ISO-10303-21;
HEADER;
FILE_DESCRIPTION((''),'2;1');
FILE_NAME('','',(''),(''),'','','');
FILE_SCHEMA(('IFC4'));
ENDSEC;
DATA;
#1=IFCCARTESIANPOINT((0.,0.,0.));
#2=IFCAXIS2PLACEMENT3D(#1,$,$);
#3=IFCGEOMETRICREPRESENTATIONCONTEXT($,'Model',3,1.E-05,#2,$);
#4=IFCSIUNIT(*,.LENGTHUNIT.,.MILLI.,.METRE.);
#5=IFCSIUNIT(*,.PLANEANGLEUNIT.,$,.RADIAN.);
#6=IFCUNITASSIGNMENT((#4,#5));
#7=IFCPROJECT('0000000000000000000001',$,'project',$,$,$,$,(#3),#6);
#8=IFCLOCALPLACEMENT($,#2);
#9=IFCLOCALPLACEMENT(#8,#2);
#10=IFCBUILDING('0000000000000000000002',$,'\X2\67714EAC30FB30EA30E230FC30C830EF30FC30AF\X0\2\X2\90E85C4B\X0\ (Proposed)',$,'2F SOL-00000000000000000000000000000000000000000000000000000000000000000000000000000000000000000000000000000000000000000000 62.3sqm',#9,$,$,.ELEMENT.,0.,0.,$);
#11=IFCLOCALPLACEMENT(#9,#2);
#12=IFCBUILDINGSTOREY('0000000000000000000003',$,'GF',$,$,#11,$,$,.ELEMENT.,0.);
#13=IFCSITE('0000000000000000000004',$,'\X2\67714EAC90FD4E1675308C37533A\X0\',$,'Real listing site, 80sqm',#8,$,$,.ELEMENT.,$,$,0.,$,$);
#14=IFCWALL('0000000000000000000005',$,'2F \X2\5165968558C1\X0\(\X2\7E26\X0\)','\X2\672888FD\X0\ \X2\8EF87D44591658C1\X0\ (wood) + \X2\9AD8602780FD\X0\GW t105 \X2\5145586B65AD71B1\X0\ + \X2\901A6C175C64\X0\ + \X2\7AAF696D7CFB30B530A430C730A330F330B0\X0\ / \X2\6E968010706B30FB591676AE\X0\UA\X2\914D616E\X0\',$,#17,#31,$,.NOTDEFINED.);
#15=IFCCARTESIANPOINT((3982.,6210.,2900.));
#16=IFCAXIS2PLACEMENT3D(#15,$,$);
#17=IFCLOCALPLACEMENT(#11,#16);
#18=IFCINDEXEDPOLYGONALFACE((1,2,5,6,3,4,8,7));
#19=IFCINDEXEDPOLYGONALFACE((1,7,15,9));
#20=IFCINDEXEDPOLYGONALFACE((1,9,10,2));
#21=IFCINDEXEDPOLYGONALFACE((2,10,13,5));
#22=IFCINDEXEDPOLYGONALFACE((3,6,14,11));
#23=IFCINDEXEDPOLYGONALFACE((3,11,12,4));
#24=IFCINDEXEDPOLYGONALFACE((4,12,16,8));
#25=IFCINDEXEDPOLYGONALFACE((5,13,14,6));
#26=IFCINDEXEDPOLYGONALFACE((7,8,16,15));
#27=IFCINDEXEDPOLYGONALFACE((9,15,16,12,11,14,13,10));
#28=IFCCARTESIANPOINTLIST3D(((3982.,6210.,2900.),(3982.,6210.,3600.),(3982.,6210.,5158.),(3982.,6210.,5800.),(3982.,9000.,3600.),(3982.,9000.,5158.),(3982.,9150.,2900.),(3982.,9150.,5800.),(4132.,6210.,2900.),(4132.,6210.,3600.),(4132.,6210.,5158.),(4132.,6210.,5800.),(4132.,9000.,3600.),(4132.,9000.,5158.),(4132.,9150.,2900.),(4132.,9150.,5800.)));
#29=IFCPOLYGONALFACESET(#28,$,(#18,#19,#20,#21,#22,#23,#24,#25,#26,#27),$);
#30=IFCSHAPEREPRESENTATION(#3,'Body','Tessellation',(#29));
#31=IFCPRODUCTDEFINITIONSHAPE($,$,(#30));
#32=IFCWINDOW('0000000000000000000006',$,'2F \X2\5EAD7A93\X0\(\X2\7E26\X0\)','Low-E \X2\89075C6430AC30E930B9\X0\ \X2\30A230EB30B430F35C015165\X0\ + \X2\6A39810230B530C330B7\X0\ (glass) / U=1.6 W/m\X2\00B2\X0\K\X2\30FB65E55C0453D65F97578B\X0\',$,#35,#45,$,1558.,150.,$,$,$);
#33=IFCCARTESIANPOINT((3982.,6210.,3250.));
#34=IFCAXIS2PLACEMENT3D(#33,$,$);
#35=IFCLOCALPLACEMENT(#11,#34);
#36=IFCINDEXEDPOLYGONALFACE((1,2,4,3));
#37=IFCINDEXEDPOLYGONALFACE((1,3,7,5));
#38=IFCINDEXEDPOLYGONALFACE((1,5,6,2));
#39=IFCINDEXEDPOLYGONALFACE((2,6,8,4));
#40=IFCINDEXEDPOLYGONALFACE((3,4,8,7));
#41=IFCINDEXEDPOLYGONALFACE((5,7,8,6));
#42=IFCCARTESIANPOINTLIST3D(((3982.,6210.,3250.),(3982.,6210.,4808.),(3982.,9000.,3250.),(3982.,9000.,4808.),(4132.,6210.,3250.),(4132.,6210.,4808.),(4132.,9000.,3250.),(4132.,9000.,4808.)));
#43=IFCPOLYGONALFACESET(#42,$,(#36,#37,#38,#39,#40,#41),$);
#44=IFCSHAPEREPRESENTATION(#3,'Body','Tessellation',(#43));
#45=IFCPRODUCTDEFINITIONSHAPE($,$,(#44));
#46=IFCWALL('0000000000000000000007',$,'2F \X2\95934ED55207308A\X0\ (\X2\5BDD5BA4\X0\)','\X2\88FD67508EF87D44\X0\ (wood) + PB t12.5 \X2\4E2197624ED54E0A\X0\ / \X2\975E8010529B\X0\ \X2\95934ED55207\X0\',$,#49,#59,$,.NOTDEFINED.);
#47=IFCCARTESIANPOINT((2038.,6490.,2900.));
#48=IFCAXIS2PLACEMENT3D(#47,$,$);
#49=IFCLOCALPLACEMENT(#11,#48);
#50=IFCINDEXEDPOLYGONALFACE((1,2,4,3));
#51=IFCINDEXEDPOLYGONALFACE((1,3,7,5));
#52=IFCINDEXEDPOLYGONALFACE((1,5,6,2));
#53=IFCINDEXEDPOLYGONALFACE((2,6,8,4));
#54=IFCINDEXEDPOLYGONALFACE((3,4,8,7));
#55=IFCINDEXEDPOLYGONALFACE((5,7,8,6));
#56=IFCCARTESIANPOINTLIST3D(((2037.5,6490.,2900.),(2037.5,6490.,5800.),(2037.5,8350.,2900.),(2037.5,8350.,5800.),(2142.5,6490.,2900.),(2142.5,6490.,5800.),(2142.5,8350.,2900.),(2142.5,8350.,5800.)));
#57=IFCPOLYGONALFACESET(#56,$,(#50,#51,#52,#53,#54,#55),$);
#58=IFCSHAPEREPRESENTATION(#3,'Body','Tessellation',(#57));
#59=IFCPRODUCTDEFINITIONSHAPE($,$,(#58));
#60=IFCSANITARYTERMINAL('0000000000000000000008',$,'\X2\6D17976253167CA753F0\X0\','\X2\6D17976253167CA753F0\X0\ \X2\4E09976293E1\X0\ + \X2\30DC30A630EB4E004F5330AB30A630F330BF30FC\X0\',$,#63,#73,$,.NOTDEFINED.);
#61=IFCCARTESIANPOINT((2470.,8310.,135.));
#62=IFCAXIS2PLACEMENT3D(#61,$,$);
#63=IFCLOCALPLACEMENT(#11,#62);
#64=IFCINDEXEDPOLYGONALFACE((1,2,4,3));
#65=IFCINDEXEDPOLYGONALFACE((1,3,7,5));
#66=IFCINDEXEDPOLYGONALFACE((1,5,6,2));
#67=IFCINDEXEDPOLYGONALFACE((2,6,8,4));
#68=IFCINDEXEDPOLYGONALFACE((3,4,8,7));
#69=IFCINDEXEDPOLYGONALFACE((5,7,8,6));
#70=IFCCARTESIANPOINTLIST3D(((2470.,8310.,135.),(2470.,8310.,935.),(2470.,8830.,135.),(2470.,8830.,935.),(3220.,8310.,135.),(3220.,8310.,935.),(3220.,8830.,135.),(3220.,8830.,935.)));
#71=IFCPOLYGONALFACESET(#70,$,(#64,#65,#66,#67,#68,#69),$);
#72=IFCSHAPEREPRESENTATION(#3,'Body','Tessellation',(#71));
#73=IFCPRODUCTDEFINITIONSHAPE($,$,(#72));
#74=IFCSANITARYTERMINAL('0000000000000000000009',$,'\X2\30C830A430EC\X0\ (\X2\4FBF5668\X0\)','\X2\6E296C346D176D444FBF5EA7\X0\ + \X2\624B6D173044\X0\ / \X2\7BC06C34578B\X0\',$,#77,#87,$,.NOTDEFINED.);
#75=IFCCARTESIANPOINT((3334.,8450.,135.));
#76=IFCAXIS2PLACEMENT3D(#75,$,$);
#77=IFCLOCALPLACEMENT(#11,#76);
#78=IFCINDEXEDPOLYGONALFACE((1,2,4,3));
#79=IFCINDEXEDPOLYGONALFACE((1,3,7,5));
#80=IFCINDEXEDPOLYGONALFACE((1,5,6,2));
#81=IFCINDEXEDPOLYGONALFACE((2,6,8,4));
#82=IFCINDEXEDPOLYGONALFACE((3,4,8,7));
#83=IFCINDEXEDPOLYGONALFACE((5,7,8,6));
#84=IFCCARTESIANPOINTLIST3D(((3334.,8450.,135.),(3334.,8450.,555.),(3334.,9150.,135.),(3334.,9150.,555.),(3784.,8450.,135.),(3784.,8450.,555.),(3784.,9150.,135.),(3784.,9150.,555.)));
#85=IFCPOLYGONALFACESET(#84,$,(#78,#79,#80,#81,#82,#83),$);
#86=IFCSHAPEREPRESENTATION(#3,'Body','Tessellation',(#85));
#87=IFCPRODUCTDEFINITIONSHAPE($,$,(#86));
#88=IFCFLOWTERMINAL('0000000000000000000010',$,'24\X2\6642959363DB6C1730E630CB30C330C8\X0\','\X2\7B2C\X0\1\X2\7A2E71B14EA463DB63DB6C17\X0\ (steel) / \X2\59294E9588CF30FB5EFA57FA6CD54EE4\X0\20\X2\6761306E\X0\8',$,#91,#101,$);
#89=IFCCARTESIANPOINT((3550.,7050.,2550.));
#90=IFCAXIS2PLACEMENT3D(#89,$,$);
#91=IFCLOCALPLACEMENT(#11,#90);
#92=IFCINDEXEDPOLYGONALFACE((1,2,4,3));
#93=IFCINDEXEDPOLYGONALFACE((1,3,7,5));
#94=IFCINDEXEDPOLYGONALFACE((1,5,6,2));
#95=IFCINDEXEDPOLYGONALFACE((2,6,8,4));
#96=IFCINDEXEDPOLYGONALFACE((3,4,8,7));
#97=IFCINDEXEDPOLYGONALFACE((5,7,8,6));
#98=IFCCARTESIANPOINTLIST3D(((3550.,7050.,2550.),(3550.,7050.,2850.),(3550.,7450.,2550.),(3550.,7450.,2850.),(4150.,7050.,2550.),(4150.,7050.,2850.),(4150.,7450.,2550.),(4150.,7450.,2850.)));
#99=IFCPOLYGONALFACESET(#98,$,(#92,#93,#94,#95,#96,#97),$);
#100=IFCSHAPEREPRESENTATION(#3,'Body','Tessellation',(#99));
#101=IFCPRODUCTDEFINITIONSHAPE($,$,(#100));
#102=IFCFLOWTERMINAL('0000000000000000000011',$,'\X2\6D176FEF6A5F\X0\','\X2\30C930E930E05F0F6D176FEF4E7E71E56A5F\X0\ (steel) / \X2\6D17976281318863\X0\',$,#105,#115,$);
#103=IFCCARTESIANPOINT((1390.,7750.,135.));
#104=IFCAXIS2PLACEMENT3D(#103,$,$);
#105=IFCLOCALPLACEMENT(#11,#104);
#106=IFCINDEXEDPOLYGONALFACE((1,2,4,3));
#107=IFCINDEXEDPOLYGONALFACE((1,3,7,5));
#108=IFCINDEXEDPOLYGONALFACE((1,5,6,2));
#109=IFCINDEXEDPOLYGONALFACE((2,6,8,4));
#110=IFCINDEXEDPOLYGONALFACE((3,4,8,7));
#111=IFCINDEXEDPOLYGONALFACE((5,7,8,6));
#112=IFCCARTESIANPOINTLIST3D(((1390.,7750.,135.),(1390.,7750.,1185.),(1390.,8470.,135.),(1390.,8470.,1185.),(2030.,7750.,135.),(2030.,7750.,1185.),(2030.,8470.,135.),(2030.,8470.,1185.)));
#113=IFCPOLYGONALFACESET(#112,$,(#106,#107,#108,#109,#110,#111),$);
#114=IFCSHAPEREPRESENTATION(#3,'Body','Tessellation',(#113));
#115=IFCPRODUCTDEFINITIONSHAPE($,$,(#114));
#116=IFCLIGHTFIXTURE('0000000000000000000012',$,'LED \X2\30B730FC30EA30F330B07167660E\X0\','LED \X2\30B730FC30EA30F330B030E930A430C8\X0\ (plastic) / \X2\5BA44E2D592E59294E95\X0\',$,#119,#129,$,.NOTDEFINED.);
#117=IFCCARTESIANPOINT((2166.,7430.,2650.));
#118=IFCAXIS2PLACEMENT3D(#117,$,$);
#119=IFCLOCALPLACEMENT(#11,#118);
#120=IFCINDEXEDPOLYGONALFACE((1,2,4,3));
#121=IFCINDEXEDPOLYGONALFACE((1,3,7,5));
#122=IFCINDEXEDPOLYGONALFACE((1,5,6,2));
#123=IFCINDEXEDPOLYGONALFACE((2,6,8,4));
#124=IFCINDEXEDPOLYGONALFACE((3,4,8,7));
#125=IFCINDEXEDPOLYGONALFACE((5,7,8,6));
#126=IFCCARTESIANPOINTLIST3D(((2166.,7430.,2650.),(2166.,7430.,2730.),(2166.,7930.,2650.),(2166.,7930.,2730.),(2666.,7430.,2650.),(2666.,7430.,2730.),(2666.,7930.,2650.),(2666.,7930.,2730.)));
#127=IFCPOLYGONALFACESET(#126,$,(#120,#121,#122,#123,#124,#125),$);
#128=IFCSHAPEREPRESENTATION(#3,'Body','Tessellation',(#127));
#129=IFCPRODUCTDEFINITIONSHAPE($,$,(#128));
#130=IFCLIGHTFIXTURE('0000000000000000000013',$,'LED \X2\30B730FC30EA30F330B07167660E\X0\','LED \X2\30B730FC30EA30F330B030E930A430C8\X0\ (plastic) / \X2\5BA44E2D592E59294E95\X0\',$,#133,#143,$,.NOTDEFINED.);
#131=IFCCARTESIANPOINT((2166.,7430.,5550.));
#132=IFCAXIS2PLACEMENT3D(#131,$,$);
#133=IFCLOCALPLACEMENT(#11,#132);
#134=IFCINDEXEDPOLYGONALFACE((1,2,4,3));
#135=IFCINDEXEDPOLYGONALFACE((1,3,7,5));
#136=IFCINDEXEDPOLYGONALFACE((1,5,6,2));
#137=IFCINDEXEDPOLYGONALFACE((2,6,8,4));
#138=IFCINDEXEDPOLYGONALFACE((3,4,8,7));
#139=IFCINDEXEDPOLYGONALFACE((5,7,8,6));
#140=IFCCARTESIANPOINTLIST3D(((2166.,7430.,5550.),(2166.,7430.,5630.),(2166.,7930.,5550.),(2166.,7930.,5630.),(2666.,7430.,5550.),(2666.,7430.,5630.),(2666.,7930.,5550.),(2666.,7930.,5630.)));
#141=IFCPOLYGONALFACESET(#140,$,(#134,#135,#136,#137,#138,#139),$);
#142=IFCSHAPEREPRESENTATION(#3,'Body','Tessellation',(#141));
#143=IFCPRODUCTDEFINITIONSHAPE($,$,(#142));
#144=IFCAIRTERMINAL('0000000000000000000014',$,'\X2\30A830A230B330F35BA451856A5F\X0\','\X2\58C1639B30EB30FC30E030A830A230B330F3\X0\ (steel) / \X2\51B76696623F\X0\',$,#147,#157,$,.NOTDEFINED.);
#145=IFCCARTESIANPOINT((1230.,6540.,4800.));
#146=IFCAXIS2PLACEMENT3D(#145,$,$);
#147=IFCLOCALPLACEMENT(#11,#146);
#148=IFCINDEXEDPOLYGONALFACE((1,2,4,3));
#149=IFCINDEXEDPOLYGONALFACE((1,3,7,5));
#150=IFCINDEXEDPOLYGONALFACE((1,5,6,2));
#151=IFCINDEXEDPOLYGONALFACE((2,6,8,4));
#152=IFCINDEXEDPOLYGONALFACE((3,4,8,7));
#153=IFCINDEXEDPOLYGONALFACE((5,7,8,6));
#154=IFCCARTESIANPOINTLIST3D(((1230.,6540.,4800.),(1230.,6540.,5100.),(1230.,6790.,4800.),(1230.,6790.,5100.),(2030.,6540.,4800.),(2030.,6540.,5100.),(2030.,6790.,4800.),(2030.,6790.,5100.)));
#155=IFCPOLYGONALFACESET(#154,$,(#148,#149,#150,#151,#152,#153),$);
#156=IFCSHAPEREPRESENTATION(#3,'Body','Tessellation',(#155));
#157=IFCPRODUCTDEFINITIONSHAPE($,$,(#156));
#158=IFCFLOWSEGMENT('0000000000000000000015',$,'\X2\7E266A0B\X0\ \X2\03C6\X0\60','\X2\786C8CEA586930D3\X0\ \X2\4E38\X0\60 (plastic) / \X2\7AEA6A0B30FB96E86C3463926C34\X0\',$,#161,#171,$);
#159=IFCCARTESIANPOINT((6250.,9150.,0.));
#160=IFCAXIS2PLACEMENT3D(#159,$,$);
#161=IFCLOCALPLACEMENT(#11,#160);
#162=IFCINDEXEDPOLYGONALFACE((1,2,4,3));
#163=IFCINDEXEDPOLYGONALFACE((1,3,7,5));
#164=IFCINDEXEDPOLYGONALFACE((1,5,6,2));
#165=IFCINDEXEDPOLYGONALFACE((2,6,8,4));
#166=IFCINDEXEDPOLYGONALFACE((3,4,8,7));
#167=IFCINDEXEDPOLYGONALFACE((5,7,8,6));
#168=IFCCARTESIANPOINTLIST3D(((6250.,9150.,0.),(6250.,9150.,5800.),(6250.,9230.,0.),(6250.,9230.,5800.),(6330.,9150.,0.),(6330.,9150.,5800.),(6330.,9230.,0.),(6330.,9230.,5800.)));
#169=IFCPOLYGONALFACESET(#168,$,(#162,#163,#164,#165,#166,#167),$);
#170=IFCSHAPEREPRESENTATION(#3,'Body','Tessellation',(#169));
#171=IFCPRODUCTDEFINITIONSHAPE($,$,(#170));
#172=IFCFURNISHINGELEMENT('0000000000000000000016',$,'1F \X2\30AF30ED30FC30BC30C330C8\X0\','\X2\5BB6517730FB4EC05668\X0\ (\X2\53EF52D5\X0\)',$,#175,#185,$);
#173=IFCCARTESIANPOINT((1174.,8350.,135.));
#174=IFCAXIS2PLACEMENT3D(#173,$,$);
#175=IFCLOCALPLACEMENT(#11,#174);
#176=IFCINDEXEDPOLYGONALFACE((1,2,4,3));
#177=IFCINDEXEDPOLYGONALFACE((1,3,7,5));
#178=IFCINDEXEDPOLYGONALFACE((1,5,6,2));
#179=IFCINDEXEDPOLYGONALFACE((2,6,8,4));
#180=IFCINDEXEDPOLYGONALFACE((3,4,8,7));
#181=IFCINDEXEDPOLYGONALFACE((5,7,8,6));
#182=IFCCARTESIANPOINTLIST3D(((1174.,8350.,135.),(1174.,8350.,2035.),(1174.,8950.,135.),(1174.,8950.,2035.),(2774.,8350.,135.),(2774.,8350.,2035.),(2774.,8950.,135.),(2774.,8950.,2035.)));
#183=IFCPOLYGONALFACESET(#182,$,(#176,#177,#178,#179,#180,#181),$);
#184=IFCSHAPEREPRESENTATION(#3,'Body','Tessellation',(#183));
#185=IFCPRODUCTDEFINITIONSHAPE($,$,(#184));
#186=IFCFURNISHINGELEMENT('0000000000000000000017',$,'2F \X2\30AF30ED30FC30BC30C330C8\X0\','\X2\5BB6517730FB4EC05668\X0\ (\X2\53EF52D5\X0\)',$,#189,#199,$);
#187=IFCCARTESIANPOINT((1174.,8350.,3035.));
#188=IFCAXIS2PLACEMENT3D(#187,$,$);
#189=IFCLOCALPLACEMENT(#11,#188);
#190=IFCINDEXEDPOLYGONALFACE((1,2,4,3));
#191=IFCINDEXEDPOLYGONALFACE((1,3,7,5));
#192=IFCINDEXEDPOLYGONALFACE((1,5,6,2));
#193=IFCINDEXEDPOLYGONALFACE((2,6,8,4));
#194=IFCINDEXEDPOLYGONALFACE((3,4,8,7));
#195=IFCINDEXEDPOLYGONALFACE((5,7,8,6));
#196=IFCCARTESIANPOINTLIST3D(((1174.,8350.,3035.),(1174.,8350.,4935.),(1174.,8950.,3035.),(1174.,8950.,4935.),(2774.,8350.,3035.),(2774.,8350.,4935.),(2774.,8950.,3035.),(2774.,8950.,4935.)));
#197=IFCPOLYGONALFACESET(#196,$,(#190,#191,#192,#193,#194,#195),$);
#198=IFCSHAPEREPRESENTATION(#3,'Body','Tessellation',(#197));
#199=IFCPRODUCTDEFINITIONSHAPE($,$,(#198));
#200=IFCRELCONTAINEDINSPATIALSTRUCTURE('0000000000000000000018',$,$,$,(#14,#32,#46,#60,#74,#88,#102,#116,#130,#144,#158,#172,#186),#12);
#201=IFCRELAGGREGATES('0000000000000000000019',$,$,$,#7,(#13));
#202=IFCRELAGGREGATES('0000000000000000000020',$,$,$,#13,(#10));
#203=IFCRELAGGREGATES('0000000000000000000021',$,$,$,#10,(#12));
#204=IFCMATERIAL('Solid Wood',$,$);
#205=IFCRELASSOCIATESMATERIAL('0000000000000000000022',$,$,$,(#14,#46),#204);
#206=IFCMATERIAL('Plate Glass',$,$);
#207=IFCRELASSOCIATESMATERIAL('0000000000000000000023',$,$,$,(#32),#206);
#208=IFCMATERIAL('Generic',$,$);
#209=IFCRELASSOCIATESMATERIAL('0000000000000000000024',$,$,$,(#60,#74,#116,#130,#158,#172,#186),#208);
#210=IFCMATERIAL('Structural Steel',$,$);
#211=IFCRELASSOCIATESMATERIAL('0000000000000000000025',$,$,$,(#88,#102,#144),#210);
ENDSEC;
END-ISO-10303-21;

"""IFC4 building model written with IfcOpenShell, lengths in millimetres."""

from ifc_helpers import new_model, si_unit, frame, frame_2d, origin, place, context, project, spatial, rectangle, extrude, material, element, fill, save


model = new_model("IFC4")

# Units and contexts
model_context = context("Model", 3, precision=1e-05, world=origin())
ifc_project = project(units=[si_unit("LENGTHUNIT", "METRE", prefix="MILLI"), si_unit("PLANEANGLEUNIT", "RADIAN")], contexts=[model_context])

# Site, building, storey
site_placement = place(None, origin())
site = spatial("IfcSite", under=ifc_project, at=site_placement, Name="東京都世田谷区", ObjectType="Real listing site, 80sqm", CompositionType="ELEMENT", RefElevation=0.0)
building_placement = place(site_placement, origin())
building = spatial("IfcBuilding", under=site, at=building_placement, Name="東京・リモートワーク2部屋 (Proposed)", ObjectType="2F SOL-00000000000000000000000000000000000000000000000000000000000000000000000000000000000000000000000000000000000000000000 62.3sqm", CompositionType="ELEMENT", ElevationOfRefHeight=0.0, ElevationOfTerrain=0.0)
storey_placement = place(building_placement, origin())
storey = spatial("IfcBuildingStorey", under=building, at=storey_placement, Name="GF", CompositionType="ELEMENT", Elevation=0.0)

# Shared definitions
ifc_material_1 = material(Name="Solid Wood")

# Shared definitions
ifc_material_2 = material(Name="Plate Glass")

# Wall, opening, window
wall_1_placement = place(storey_placement, frame((3982.0, 6210.0, 2900.0)))
wall_1 = element("IfcWall", 1, at=wall_1_placement, inside=storey, material=ifc_material_1, Name="2F 入隅壁(縦)", Description="木製 軸組外壁 (wood) + 高性能GW t105 充填断熱 + 通気層 + 窯業系サイディング / 準耐火・外皮UA配慮", PredefinedType="NOTDEFINED", context=model_context, shape_type="SweptSolid", body=[
    extrude(rectangle(XDim=150.0, YDim=2940.0, at=frame_2d((75.0, 1470.0))), frame((3982.0, 6210.0, 2900.0)), (0.0, 0.0, 1.0), 2900.0),
])
opening_1_placement = place(storey_placement, frame((3982.0, 6210.0, 3250.0)))
opening_1 = element("IfcOpeningElement", 2, at=opening_1_placement, cuts=wall_1, PredefinedType="NOTDEFINED", context=model_context, shape_type="SweptSolid", body=[
    extrude(rectangle(XDim=150.0, YDim=2790.0, at=frame_2d((75.0, 1395.0))), frame((3982.0, 6210.0, 3250.0)), (0.0, 0.0, 1.0), 1558.0),
])
window_1_placement = place(storey_placement, frame((3982.0, 6210.0, 3250.0)))
window_1 = element("IfcWindow", 3, at=window_1_placement, inside=storey, material=ifc_material_2, Name="2F 庭窓(縦)", Description="Low-E 複層ガラス アルゴン封入 + 樹脂サッシ (glass) / U=1.6 W/m²K・日射取得型", OverallHeight=1558.0, OverallWidth=150.0, context=model_context, shape_type="SweptSolid", body=[
    extrude(rectangle(XDim=150.0, YDim=2790.0, at=frame_2d((75.0, 1395.0))), frame((3982.0, 6210.0, 3250.0)), (0.0, 0.0, 1.0), 1558.0),
])
fill(opening_1, window_1)

# Wall
wall_2_placement = place(storey_placement, frame((2038.0, 6490.0, 2900.0)))
element("IfcWall", 4, at=wall_2_placement, inside=storey, material=ifc_material_1, Name="2F 間仕切り (寝室)", Description="製材軸組 (wood) + PB t12.5 両面仕上 / 非耐力 間仕切", PredefinedType="NOTDEFINED", context=model_context, shape_type="SweptSolid", body=[
    extrude(rectangle(XDim=105.0, YDim=1860.0, at=frame_2d((52.0, 930.0))), frame((2038.0, 6490.0, 2900.0)), (0.0, 0.0, 1.0), 2900.0),
])

# Sanitary terminals
ifc_material_3 = material(Name="Generic")
sanitary_terminal_1_placement = place(storey_placement, frame((2470.0, 8310.0, 135.0)))
element("IfcSanitaryTerminal", 5, at=sanitary_terminal_1_placement, inside=storey, material=ifc_material_3, Name="洗面化粧台", Description="洗面化粧台 三面鏡 + ボウル一体カウンター", PredefinedType="NOTDEFINED", context=model_context, shape_type="SweptSolid", body=[
    extrude(rectangle(XDim=750.0, YDim=520.0, at=frame_2d((375.0, 260.0))), frame((2470.0, 8310.0, 135.0)), (0.0, 0.0, 1.0), 800.0),
])
sanitary_terminal_2_placement = place(storey_placement, frame((3334.0, 8450.0, 135.0)))
element("IfcSanitaryTerminal", 6, at=sanitary_terminal_2_placement, inside=storey, material=ifc_material_3, Name="トイレ (便器)", Description="温水洗浄便座 + 手洗い / 節水型", PredefinedType="NOTDEFINED", context=model_context, shape_type="SweptSolid", body=[
    extrude(rectangle(XDim=450.0, YDim=700.0, at=frame_2d((225.0, 350.0))), frame((3334.0, 8450.0, 135.0)), (0.0, 0.0, 1.0), 420.0),
])

# Flow terminals
ifc_material_4 = material(Name="Structural Steel")
flow_terminal_1_placement = place(storey_placement, frame((3550.0, 7050.0, 2550.0)))
element("IfcFlowTerminal", 7, at=flow_terminal_1_placement, inside=storey, material=ifc_material_4, Name="24時間換気ユニット", Description="第1種熱交換換気 (steel) / 天井裏・建基法令20条の8", context=model_context, shape_type="SweptSolid", body=[
    extrude(rectangle(XDim=600.0, YDim=400.0, at=frame_2d((300.0, 200.0))), frame((3550.0, 7050.0, 2550.0)), (0.0, 0.0, 1.0), 300.0),
])
flow_terminal_2_placement = place(storey_placement, frame((1390.0, 7750.0, 135.0)))
element("IfcFlowTerminal", 8, at=flow_terminal_2_placement, inside=storey, material=ifc_material_4, Name="洗濯機", Description="ドラム式洗濯乾燥機 (steel) / 洗面脱衣", context=model_context, shape_type="SweptSolid", body=[
    extrude(rectangle(XDim=640.0, YDim=720.0, at=frame_2d((320.0, 360.0))), frame((1390.0, 7750.0, 135.0)), (0.0, 0.0, 1.0), 1050.0),
])

# Light fixtures
light_fixture_1_placement = place(storey_placement, frame((2166.0, 7430.0, 2650.0)))
element("IfcLightFixture", 9, at=light_fixture_1_placement, inside=storey, material=ifc_material_3, Name="LED シーリング照明", Description="LED シーリングライト (plastic) / 室中央天井", PredefinedType="NOTDEFINED", context=model_context, shape_type="SweptSolid", body=[
    extrude(rectangle(XDim=500.0, YDim=500.0, at=frame_2d((250.0, 250.0))), frame((2166.0, 7430.0, 2650.0)), (0.0, 0.0, 1.0), 80.0),
])
light_fixture_2_placement = place(storey_placement, frame((2166.0, 7430.0, 5550.0)))
element("IfcLightFixture", 10, at=light_fixture_2_placement, inside=storey, material=ifc_material_3, Name="LED シーリング照明", Description="LED シーリングライト (plastic) / 室中央天井", PredefinedType="NOTDEFINED", context=model_context, shape_type="SweptSolid", body=[
    extrude(rectangle(XDim=500.0, YDim=500.0, at=frame_2d((250.0, 250.0))), frame((2166.0, 7430.0, 5550.0)), (0.0, 0.0, 1.0), 80.0),
])

# Air terminal
air_terminal_placement = place(storey_placement, frame((1230.0, 6540.0, 4800.0)))
element("IfcAirTerminal", 11, at=air_terminal_placement, inside=storey, material=ifc_material_4, Name="エアコン室内機", Description="壁掛ルームエアコン (steel) / 冷暖房", PredefinedType="NOTDEFINED", context=model_context, shape_type="SweptSolid", body=[
    extrude(rectangle(XDim=800.0, YDim=250.0, at=frame_2d((400.0, 125.0))), frame((1230.0, 6540.0, 4800.0)), (0.0, 0.0, 1.0), 300.0),
])

# Flow segment
flow_segment_placement = place(storey_placement, frame((6250.0, 9150.0, 0.0)))
element("IfcFlowSegment", 12, at=flow_segment_placement, inside=storey, material=ifc_material_3, Name="縦樋 φ60", Description="硬質塩ビ 丸60 (plastic) / 竪樋・雨水排水", context=model_context, shape_type="SweptSolid", body=[
    extrude(rectangle(XDim=80.0, YDim=80.0, at=frame_2d((40.0, 40.0))), frame((6250.0, 9150.0, 0.0)), (0.0, 0.0, 1.0), 5800.0),
])

# Furnishing elements
furnishing_1_placement = place(storey_placement, frame((1174.0, 8350.0, 135.0)))
element("IfcFurnishingElement", 13, at=furnishing_1_placement, inside=storey, material=ifc_material_3, Name="1F クローゼット", Description="家具・什器 (可動)", context=model_context, shape_type="SweptSolid", body=[
    extrude(rectangle(XDim=1600.0, YDim=600.0, at=frame_2d((800.0, 300.0))), frame((1174.0, 8350.0, 135.0)), (0.0, 0.0, 1.0), 1900.0),
])
furnishing_2_placement = place(storey_placement, frame((1174.0, 8350.0, 3035.0)))
element("IfcFurnishingElement", 14, at=furnishing_2_placement, inside=storey, material=ifc_material_3, Name="2F クローゼット", Description="家具・什器 (可動)", context=model_context, shape_type="SweptSolid", body=[
    extrude(rectangle(XDim=1600.0, YDim=600.0, at=frame_2d((800.0, 300.0))), frame((1174.0, 8350.0, 3035.0)), (0.0, 0.0, 1.0), 1900.0),
])

save(model, "model.ifc")
